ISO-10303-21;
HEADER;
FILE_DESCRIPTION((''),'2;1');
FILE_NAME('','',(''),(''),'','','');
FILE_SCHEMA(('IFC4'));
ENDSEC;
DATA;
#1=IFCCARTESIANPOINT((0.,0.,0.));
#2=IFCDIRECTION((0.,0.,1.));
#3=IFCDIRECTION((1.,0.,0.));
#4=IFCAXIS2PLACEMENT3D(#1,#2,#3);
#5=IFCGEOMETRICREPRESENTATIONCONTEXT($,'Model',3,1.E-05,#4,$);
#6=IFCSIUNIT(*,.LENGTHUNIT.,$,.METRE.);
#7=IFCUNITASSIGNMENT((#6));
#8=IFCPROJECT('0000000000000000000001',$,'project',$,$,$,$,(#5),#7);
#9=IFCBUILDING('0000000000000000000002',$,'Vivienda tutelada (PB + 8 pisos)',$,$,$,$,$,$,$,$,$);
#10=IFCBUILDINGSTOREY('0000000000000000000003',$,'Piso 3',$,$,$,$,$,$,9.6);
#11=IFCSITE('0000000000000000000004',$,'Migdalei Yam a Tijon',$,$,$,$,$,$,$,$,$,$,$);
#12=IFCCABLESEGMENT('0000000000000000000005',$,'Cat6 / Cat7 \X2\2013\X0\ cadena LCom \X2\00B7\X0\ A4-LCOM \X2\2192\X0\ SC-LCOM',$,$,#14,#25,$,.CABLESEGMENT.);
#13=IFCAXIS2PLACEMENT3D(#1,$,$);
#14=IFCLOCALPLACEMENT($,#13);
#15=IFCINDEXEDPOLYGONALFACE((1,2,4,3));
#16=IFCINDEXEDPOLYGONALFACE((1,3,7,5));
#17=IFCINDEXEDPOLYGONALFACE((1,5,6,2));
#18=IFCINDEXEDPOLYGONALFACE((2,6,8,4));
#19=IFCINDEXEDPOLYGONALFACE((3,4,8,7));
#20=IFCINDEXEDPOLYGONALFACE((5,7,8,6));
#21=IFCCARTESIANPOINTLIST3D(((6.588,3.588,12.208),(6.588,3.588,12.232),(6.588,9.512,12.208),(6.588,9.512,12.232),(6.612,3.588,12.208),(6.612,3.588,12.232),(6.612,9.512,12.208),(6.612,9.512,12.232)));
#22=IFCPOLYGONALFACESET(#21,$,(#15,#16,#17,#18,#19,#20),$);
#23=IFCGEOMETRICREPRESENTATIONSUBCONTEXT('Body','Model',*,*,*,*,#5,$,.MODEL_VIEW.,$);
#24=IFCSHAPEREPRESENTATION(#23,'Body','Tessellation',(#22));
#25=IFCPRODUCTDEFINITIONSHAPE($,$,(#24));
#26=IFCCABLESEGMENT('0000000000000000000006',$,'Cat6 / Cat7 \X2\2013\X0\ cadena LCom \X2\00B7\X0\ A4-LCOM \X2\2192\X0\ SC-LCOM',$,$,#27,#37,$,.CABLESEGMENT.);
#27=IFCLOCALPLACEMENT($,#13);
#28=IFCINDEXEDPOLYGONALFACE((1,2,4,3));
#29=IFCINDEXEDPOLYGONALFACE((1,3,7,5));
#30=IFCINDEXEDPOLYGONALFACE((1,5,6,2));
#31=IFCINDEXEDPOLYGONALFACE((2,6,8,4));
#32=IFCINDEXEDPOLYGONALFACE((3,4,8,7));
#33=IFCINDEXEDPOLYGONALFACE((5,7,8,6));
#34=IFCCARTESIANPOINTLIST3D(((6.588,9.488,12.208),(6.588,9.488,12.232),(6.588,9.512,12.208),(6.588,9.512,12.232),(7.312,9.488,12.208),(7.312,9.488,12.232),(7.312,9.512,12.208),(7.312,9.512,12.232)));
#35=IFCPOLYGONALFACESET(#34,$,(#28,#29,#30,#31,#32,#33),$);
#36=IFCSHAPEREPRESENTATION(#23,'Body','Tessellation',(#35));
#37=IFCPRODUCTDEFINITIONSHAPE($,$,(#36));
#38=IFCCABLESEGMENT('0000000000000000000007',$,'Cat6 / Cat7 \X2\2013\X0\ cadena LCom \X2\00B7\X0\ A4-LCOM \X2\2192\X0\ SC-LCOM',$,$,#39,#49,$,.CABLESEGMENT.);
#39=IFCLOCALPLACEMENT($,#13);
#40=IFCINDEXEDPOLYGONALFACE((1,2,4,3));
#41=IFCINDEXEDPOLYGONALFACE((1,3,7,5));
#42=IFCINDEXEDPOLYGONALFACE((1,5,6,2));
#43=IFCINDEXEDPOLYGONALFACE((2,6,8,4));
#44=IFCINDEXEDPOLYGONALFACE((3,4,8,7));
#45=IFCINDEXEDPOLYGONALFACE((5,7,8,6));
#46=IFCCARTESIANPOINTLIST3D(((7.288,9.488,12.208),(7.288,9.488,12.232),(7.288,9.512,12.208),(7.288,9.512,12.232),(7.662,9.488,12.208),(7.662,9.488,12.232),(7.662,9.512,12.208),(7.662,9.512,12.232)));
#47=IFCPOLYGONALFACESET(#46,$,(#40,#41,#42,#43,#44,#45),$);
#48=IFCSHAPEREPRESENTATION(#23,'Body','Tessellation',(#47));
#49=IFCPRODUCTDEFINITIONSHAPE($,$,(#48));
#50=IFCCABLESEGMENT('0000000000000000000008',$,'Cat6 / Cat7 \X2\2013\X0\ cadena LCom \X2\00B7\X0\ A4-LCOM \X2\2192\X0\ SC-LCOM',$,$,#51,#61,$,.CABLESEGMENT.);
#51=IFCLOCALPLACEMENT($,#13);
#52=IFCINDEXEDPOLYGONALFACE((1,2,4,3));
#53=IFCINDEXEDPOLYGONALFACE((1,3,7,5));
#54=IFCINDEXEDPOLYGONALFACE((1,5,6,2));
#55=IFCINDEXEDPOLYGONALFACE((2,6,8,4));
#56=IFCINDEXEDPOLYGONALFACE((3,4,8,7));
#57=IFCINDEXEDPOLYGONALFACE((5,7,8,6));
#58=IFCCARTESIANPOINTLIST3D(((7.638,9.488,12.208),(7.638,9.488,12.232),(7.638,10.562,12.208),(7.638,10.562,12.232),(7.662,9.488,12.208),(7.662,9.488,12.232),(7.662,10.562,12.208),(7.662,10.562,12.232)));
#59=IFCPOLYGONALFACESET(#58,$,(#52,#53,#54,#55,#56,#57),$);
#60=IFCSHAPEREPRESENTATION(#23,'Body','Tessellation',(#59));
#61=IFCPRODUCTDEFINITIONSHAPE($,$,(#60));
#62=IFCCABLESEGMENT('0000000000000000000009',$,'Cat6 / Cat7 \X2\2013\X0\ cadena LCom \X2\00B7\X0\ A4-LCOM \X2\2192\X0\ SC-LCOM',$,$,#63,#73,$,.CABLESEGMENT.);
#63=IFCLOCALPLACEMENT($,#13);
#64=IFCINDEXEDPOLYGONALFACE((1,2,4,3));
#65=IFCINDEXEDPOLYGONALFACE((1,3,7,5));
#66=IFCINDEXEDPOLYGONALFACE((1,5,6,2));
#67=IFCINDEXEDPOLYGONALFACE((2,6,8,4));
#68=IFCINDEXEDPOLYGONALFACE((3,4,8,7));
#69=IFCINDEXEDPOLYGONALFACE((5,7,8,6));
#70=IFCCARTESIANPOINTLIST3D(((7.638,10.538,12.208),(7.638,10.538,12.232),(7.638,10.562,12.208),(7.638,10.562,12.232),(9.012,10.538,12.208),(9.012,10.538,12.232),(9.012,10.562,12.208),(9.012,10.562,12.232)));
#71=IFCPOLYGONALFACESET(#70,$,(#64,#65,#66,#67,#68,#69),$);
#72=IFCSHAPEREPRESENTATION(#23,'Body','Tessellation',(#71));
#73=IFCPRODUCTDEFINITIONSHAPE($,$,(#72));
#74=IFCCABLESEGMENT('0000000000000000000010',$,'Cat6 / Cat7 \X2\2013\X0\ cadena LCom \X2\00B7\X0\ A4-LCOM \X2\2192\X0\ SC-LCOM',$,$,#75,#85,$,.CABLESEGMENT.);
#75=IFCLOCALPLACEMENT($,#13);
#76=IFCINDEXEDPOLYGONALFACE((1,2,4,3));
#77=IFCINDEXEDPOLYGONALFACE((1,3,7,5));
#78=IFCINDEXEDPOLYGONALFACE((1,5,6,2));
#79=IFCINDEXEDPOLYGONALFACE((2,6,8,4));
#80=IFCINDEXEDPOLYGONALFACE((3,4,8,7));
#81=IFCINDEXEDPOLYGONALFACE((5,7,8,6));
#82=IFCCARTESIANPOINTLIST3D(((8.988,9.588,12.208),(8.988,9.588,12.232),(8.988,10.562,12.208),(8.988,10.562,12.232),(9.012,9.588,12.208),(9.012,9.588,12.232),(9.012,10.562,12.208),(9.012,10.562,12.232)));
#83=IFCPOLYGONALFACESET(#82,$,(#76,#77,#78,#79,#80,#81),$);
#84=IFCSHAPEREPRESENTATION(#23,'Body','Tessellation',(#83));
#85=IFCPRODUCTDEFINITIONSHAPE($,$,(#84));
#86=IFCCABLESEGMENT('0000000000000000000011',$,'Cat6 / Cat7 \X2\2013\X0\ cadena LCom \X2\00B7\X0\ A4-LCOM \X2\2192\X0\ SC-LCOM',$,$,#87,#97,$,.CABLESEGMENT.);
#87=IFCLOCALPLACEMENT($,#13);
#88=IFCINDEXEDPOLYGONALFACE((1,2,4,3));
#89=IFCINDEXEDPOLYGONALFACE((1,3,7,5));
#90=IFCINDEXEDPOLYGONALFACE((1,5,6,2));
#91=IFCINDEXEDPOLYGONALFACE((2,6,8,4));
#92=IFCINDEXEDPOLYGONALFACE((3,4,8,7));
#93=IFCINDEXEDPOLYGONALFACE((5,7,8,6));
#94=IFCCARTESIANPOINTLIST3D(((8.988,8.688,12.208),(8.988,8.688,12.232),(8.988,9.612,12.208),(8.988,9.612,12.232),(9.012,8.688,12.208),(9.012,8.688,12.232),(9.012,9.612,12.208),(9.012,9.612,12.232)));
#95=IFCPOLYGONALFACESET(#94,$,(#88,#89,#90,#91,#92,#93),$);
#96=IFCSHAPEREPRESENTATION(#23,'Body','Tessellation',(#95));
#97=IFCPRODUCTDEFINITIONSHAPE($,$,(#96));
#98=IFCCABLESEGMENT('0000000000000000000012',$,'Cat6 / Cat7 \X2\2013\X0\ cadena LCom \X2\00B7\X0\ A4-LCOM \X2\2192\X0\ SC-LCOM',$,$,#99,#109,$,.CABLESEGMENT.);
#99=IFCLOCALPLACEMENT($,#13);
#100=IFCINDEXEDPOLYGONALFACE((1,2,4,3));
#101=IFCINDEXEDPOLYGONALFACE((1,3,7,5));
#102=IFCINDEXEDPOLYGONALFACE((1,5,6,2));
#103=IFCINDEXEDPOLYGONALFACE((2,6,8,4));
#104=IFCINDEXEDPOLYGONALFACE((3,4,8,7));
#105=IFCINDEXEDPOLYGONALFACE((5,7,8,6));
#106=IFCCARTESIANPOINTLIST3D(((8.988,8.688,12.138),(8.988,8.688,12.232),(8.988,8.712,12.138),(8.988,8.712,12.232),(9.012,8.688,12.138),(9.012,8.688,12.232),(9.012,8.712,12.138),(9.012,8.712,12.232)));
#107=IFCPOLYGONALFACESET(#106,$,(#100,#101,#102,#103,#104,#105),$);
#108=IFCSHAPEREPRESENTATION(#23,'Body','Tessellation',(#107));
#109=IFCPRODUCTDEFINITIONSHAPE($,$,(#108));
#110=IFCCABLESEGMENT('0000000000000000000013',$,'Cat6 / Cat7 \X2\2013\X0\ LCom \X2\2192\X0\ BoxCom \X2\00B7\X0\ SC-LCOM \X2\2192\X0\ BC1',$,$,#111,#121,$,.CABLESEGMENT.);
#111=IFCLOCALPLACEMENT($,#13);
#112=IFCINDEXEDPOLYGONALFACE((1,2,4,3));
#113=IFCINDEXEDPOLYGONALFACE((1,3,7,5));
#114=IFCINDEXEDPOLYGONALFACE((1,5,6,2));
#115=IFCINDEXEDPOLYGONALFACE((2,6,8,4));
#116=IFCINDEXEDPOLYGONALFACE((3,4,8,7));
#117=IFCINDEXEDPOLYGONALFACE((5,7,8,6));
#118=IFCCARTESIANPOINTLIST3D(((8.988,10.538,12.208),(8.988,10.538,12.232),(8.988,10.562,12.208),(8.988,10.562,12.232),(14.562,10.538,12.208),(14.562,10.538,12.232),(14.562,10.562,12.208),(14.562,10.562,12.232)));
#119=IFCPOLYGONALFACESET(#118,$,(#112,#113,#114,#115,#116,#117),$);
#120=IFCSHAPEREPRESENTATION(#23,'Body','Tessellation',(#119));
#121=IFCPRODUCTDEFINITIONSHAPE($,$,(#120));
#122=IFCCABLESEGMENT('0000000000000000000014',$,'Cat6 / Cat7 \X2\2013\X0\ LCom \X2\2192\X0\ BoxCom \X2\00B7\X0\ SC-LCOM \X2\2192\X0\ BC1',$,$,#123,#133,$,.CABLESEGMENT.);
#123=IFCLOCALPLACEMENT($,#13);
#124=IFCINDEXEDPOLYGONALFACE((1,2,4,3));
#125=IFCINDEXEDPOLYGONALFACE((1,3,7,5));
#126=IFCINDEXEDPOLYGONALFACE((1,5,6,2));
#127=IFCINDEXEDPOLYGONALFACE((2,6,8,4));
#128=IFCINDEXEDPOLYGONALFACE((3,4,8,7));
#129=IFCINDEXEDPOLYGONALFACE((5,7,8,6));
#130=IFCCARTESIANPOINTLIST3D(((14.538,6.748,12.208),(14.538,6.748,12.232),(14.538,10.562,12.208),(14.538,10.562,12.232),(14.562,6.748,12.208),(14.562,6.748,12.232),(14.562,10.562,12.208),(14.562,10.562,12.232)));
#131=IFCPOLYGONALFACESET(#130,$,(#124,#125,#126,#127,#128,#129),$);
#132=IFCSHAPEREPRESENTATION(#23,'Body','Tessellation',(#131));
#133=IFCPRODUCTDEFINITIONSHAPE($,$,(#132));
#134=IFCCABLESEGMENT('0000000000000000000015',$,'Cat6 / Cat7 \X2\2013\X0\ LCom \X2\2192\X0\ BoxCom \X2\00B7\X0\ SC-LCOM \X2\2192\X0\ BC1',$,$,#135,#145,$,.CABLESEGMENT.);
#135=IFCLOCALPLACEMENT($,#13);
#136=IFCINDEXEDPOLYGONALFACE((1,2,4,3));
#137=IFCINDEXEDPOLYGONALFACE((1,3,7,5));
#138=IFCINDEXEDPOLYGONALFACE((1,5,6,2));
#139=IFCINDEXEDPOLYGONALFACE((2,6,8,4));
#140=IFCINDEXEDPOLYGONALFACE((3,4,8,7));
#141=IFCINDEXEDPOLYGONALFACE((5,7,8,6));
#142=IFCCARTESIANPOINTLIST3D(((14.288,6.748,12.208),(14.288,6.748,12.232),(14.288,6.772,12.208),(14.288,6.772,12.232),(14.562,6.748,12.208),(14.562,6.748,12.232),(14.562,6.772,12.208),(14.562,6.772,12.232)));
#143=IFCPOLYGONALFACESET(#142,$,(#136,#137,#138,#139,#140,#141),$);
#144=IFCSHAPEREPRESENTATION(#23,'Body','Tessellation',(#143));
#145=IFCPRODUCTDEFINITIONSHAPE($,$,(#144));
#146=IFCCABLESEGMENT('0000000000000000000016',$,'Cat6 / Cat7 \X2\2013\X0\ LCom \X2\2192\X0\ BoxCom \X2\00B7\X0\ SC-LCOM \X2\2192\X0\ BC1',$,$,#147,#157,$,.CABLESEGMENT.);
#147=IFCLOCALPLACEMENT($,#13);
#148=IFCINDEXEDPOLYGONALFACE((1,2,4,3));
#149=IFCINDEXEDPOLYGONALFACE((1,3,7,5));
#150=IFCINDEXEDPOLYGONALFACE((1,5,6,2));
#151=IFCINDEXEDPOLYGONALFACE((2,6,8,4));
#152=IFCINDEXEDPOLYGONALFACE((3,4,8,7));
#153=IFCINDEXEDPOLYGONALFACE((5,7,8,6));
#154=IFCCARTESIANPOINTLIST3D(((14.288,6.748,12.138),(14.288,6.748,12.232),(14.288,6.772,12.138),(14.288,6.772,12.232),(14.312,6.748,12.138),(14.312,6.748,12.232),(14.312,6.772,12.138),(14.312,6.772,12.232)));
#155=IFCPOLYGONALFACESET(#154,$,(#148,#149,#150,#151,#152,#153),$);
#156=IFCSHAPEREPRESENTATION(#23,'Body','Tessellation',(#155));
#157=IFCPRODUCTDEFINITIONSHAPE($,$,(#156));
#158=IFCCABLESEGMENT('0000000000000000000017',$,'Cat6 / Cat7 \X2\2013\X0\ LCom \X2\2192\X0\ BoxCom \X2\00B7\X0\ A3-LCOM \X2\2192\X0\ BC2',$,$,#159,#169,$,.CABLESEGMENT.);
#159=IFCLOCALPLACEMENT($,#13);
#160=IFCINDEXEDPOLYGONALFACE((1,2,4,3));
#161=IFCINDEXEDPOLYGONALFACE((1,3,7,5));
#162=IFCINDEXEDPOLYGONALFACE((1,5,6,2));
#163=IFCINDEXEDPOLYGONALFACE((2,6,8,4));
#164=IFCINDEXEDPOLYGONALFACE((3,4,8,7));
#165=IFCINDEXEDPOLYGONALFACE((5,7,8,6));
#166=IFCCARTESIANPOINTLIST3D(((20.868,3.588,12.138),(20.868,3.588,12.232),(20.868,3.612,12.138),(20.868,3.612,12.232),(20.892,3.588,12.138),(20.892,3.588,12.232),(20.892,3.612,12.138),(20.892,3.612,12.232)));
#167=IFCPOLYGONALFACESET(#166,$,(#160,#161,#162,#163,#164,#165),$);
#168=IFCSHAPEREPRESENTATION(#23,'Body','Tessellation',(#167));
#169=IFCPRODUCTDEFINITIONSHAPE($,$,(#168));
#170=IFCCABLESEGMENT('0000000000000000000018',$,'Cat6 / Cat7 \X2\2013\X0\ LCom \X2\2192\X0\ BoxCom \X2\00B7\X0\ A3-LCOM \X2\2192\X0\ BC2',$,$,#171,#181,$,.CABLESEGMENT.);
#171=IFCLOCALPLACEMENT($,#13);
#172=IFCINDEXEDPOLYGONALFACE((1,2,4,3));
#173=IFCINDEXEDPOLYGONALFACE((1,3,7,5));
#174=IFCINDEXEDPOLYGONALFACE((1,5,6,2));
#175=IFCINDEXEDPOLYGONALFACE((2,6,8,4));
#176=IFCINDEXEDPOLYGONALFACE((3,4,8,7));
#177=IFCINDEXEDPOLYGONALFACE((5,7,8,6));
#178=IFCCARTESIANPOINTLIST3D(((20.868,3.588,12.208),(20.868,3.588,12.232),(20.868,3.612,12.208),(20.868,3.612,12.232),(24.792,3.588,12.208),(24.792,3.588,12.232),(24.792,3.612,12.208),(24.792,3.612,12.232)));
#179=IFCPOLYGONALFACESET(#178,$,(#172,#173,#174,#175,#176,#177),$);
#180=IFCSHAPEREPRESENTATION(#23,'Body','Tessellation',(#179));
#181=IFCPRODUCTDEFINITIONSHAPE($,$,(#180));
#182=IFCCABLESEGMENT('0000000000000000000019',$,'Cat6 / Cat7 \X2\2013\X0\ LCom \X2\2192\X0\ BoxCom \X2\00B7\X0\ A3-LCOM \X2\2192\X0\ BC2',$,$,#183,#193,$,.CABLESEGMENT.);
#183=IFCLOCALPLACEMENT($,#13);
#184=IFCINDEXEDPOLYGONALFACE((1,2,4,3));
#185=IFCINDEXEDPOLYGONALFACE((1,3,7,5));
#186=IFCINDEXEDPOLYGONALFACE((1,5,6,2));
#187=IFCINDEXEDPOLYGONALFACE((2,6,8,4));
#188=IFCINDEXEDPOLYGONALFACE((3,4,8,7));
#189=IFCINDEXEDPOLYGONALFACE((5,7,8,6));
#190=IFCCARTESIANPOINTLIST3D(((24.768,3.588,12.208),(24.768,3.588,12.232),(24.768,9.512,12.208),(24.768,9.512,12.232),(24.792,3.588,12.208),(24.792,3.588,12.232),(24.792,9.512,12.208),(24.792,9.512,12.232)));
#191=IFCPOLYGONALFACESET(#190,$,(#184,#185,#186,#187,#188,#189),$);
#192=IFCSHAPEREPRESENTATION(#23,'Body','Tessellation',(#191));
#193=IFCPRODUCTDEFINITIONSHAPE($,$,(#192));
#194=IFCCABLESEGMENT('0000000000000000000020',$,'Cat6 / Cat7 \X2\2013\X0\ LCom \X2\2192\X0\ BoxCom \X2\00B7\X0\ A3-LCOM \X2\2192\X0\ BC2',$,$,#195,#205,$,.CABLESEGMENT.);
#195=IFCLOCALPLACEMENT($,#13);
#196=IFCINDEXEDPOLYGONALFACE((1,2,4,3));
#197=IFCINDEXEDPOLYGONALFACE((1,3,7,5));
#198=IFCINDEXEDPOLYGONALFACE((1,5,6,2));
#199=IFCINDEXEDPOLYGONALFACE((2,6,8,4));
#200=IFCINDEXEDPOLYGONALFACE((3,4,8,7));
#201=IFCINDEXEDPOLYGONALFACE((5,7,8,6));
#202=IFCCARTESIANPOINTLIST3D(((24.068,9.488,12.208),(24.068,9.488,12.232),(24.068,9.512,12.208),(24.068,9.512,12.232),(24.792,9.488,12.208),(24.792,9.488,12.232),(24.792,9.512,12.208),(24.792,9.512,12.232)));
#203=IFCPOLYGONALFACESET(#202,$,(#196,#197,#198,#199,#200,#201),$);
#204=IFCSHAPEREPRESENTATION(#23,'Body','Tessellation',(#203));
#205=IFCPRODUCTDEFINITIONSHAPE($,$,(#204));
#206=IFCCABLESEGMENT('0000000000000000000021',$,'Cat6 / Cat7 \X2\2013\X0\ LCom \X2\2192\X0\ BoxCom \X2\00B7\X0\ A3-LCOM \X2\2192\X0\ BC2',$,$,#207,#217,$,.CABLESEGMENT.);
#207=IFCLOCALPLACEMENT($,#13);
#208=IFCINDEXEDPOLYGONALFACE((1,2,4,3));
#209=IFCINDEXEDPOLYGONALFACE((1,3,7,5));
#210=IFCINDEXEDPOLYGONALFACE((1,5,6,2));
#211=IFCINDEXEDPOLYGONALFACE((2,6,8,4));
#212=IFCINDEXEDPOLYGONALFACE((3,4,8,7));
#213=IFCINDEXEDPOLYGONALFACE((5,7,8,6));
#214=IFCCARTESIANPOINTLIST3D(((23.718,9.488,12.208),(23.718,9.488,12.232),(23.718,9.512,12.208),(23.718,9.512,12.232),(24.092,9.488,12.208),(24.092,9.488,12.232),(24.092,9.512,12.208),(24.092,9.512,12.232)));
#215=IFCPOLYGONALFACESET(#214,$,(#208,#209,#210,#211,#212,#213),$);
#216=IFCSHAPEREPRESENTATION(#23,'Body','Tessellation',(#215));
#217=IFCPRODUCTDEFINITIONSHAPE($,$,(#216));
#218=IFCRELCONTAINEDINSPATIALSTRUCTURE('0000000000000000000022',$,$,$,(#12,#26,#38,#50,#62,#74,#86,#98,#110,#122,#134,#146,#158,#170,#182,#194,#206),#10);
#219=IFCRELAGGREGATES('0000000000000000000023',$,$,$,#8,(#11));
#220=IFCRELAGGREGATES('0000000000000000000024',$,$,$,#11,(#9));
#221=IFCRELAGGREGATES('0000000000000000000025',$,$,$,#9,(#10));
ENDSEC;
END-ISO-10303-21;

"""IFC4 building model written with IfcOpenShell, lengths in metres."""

from ifc_helpers import new_model, si_unit, frame, origin_with_axes, context, subcontext, project, spatial, line, indexed_curve, outline, extrude, element, save


model = new_model("IFC4")

# Units and contexts
model_context = context("Model", 3, precision=1e-05, world=origin_with_axes())
body_context = subcontext(model_context, "Body", "Model", "MODEL_VIEW")
ifc_project = project(units=[si_unit("LENGTHUNIT", "METRE")], contexts=[model_context])

# Site, building, storey
site = spatial("IfcSite", under=ifc_project, Name="Migdalei Yam a Tijon")
building = spatial("IfcBuilding", under=site, Name="Vivienda tutelada (PB + 8 pisos)")
storey = spatial("IfcBuildingStorey", under=building, Name="Piso 3", Elevation=9.6)

# Cable segments
element("IfcCableSegment", 1, inside=storey, Name="Cat6 / Cat7 – cadena LCom · A4-LCOM → SC-LCOM", PredefinedType="CABLESEGMENT", context=body_context, shape_type="SweptSolid", body=[
    extrude(outline(indexed_curve([(0.0, 0.0), (0.024, 0.0), (0.024, 5.924), (0.0, 5.924)], segments=[line(1, 2, 3, 4, 1)])), frame((6.588, 3.588, 12.208), z_axis=(0.0, 0.0, 1.0), x_axis=(1.0, 0.0, 0.0)), (0.0, 0.0, 1.0), 0.024),
])
element("IfcCableSegment", 2, inside=storey, Name="Cat6 / Cat7 – cadena LCom · A4-LCOM → SC-LCOM", PredefinedType="CABLESEGMENT", context=body_context, shape_type="SweptSolid", body=[
    extrude(outline(indexed_curve([(0.0, 0.0), (0.724, 0.0), (0.724, 0.024), (0.0, 0.024)], segments=[line(1, 2, 3, 4, 1)])), frame((6.588, 9.488, 12.208), z_axis=(0.0, 0.0, 1.0), x_axis=(1.0, 0.0, 0.0)), (0.0, 0.0, 1.0), 0.024),
])
element("IfcCableSegment", 3, inside=storey, Name="Cat6 / Cat7 – cadena LCom · A4-LCOM → SC-LCOM", PredefinedType="CABLESEGMENT", context=body_context, shape_type="SweptSolid", body=[
    extrude(outline(indexed_curve([(0.0, 0.0), (0.374, 0.0), (0.374, 0.024), (0.0, 0.024)], segments=[line(1, 2, 3, 4, 1)])), frame((7.288, 9.488, 12.208), z_axis=(0.0, 0.0, 1.0), x_axis=(1.0, 0.0, 0.0)), (0.0, 0.0, 1.0), 0.024),
])
element("IfcCableSegment", 4, inside=storey, Name="Cat6 / Cat7 – cadena LCom · A4-LCOM → SC-LCOM", PredefinedType="CABLESEGMENT", context=body_context, shape_type="SweptSolid", body=[
    extrude(outline(indexed_curve([(0.0, 0.0), (0.024, 0.0), (0.024, 1.074), (0.0, 1.074)], segments=[line(1, 2, 3, 4, 1)])), frame((7.638, 9.488, 12.208), z_axis=(0.0, 0.0, 1.0), x_axis=(1.0, 0.0, 0.0)), (0.0, 0.0, 1.0), 0.024),
])
element("IfcCableSegment", 5, inside=storey, Name="Cat6 / Cat7 – cadena LCom · A4-LCOM → SC-LCOM", PredefinedType="CABLESEGMENT", context=body_context, shape_type="SweptSolid", body=[
    extrude(outline(indexed_curve([(0.0, 0.0), (1.374, 0.0), (1.374, 0.024), (0.0, 0.024)], segments=[line(1, 2, 3, 4, 1)])), frame((7.638, 10.538, 12.208), z_axis=(0.0, 0.0, 1.0), x_axis=(1.0, 0.0, 0.0)), (0.0, 0.0, 1.0), 0.024),
])
element("IfcCableSegment", 6, inside=storey, Name="Cat6 / Cat7 – cadena LCom · A4-LCOM → SC-LCOM", PredefinedType="CABLESEGMENT", context=body_context, shape_type="SweptSolid", body=[
    extrude(outline(indexed_curve([(0.0, 0.0), (0.024, 0.0), (0.024, 0.974), (0.0, 0.974)], segments=[line(1, 2, 3, 4, 1)])), frame((8.988, 9.588, 12.208), z_axis=(0.0, 0.0, 1.0), x_axis=(1.0, 0.0, 0.0)), (0.0, 0.0, 1.0), 0.024),
])
element("IfcCableSegment", 7, inside=storey, Name="Cat6 / Cat7 – cadena LCom · A4-LCOM → SC-LCOM", PredefinedType="CABLESEGMENT", context=body_context, shape_type="SweptSolid", body=[
    extrude(outline(indexed_curve([(0.0, 0.0), (0.024, 0.0), (0.024, 0.924), (0.0, 0.924)], segments=[line(1, 2, 3, 4, 1)])), frame((8.988, 8.688, 12.208), z_axis=(0.0, 0.0, 1.0), x_axis=(1.0, 0.0, 0.0)), (0.0, 0.0, 1.0), 0.024),
])
element("IfcCableSegment", 8, inside=storey, Name="Cat6 / Cat7 – cadena LCom · A4-LCOM → SC-LCOM", PredefinedType="CABLESEGMENT", context=body_context, shape_type="SweptSolid", body=[
    extrude(outline(indexed_curve([(0.0, 0.0), (0.024, 0.0), (0.024, 0.024), (0.0, 0.024)], segments=[line(1, 2, 3, 4, 1)])), frame((8.988, 8.688, 12.138), z_axis=(0.0, 0.0, 1.0), x_axis=(1.0, 0.0, 0.0)), (0.0, 0.0, 1.0), 0.094),
])
element("IfcCableSegment", 9, inside=storey, Name="Cat6 / Cat7 – LCom → BoxCom · SC-LCOM → BC1", PredefinedType="CABLESEGMENT", context=body_context, shape_type="SweptSolid", body=[
    extrude(outline(indexed_curve([(0.0, 0.0), (5.574, 0.0), (5.574, 0.024), (0.0, 0.024)], segments=[line(1, 2, 3, 4, 1)])), frame((8.988, 10.538, 12.208), z_axis=(0.0, 0.0, 1.0), x_axis=(1.0, 0.0, 0.0)), (0.0, 0.0, 1.0), 0.024),
])
element("IfcCableSegment", 10, inside=storey, Name="Cat6 / Cat7 – LCom → BoxCom · SC-LCOM → BC1", PredefinedType="CABLESEGMENT", context=body_context, shape_type="SweptSolid", body=[
    extrude(outline(indexed_curve([(0.0, 0.0), (0.024, 0.0), (0.024, 3.814), (0.0, 3.814)], segments=[line(1, 2, 3, 4, 1)])), frame((14.538, 6.748, 12.208), z_axis=(0.0, 0.0, 1.0), x_axis=(1.0, 0.0, 0.0)), (0.0, 0.0, 1.0), 0.024),
])
element("IfcCableSegment", 11, inside=storey, Name="Cat6 / Cat7 – LCom → BoxCom · SC-LCOM → BC1", PredefinedType="CABLESEGMENT", context=body_context, shape_type="SweptSolid", body=[
    extrude(outline(indexed_curve([(0.0, 0.0), (0.274, 0.0), (0.274, 0.024), (0.0, 0.024)], segments=[line(1, 2, 3, 4, 1)])), frame((14.288, 6.748, 12.208), z_axis=(0.0, 0.0, 1.0), x_axis=(1.0, 0.0, 0.0)), (0.0, 0.0, 1.0), 0.024),
])
element("IfcCableSegment", 12, inside=storey, Name="Cat6 / Cat7 – LCom → BoxCom · SC-LCOM → BC1", PredefinedType="CABLESEGMENT", context=body_context, shape_type="SweptSolid", body=[
    extrude(outline(indexed_curve([(0.0, 0.0), (0.024, 0.0), (0.024, 0.024), (0.0, 0.024)], segments=[line(1, 2, 3, 4, 1)])), frame((14.288, 6.748, 12.138), z_axis=(0.0, 0.0, 1.0), x_axis=(1.0, 0.0, 0.0)), (0.0, 0.0, 1.0), 0.094),
])
element("IfcCableSegment", 13, inside=storey, Name="Cat6 / Cat7 – LCom → BoxCom · A3-LCOM → BC2", PredefinedType="CABLESEGMENT", context=body_context, shape_type="SweptSolid", body=[
    extrude(outline(indexed_curve([(0.0, 0.0), (0.024, 0.0), (0.024, 0.024), (0.0, 0.024)], segments=[line(1, 2, 3, 4, 1)])), frame((20.868, 3.588, 12.138), z_axis=(0.0, 0.0, 1.0), x_axis=(1.0, 0.0, 0.0)), (0.0, 0.0, 1.0), 0.094),
])
element("IfcCableSegment", 14, inside=storey, Name="Cat6 / Cat7 – LCom → BoxCom · A3-LCOM → BC2", PredefinedType="CABLESEGMENT", context=body_context, shape_type="SweptSolid", body=[
    extrude(outline(indexed_curve([(0.0, 0.0), (3.924, 0.0), (3.924, 0.024), (0.0, 0.024)], segments=[line(1, 2, 3, 4, 1)])), frame((20.868, 3.588, 12.208), z_axis=(0.0, 0.0, 1.0), x_axis=(1.0, 0.0, 0.0)), (0.0, 0.0, 1.0), 0.024),
])
element("IfcCableSegment", 15, inside=storey, Name="Cat6 / Cat7 – LCom → BoxCom · A3-LCOM → BC2", PredefinedType="CABLESEGMENT", context=body_context, shape_type="SweptSolid", body=[
    extrude(outline(indexed_curve([(0.0, 0.0), (0.024, 0.0), (0.024, 5.924), (0.0, 5.924)], segments=[line(1, 2, 3, 4, 1)])), frame((24.768, 3.588, 12.208), z_axis=(0.0, 0.0, 1.0), x_axis=(1.0, 0.0, 0.0)), (0.0, 0.0, 1.0), 0.024),
])
element("IfcCableSegment", 16, inside=storey, Name="Cat6 / Cat7 – LCom → BoxCom · A3-LCOM → BC2", PredefinedType="CABLESEGMENT", context=body_context, shape_type="SweptSolid", body=[
    extrude(outline(indexed_curve([(0.0, 0.0), (0.724, 0.0), (0.724, 0.024), (0.0, 0.024)], segments=[line(1, 2, 3, 4, 1)])), frame((24.068, 9.488, 12.208), z_axis=(0.0, 0.0, 1.0), x_axis=(1.0, 0.0, 0.0)), (0.0, 0.0, 1.0), 0.024),
])
element("IfcCableSegment", 17, inside=storey, Name="Cat6 / Cat7 – LCom → BoxCom · A3-LCOM → BC2", PredefinedType="CABLESEGMENT", context=body_context, shape_type="SweptSolid", body=[
    extrude(outline(indexed_curve([(0.0, 0.0), (0.374, 0.0), (0.374, 0.024), (0.0, 0.024)], segments=[line(1, 2, 3, 4, 1)])), frame((23.718, 9.488, 12.208), z_axis=(0.0, 0.0, 1.0), x_axis=(1.0, 0.0, 0.0)), (0.0, 0.0, 1.0), 0.024),
])

save(model, "model.ifc")
